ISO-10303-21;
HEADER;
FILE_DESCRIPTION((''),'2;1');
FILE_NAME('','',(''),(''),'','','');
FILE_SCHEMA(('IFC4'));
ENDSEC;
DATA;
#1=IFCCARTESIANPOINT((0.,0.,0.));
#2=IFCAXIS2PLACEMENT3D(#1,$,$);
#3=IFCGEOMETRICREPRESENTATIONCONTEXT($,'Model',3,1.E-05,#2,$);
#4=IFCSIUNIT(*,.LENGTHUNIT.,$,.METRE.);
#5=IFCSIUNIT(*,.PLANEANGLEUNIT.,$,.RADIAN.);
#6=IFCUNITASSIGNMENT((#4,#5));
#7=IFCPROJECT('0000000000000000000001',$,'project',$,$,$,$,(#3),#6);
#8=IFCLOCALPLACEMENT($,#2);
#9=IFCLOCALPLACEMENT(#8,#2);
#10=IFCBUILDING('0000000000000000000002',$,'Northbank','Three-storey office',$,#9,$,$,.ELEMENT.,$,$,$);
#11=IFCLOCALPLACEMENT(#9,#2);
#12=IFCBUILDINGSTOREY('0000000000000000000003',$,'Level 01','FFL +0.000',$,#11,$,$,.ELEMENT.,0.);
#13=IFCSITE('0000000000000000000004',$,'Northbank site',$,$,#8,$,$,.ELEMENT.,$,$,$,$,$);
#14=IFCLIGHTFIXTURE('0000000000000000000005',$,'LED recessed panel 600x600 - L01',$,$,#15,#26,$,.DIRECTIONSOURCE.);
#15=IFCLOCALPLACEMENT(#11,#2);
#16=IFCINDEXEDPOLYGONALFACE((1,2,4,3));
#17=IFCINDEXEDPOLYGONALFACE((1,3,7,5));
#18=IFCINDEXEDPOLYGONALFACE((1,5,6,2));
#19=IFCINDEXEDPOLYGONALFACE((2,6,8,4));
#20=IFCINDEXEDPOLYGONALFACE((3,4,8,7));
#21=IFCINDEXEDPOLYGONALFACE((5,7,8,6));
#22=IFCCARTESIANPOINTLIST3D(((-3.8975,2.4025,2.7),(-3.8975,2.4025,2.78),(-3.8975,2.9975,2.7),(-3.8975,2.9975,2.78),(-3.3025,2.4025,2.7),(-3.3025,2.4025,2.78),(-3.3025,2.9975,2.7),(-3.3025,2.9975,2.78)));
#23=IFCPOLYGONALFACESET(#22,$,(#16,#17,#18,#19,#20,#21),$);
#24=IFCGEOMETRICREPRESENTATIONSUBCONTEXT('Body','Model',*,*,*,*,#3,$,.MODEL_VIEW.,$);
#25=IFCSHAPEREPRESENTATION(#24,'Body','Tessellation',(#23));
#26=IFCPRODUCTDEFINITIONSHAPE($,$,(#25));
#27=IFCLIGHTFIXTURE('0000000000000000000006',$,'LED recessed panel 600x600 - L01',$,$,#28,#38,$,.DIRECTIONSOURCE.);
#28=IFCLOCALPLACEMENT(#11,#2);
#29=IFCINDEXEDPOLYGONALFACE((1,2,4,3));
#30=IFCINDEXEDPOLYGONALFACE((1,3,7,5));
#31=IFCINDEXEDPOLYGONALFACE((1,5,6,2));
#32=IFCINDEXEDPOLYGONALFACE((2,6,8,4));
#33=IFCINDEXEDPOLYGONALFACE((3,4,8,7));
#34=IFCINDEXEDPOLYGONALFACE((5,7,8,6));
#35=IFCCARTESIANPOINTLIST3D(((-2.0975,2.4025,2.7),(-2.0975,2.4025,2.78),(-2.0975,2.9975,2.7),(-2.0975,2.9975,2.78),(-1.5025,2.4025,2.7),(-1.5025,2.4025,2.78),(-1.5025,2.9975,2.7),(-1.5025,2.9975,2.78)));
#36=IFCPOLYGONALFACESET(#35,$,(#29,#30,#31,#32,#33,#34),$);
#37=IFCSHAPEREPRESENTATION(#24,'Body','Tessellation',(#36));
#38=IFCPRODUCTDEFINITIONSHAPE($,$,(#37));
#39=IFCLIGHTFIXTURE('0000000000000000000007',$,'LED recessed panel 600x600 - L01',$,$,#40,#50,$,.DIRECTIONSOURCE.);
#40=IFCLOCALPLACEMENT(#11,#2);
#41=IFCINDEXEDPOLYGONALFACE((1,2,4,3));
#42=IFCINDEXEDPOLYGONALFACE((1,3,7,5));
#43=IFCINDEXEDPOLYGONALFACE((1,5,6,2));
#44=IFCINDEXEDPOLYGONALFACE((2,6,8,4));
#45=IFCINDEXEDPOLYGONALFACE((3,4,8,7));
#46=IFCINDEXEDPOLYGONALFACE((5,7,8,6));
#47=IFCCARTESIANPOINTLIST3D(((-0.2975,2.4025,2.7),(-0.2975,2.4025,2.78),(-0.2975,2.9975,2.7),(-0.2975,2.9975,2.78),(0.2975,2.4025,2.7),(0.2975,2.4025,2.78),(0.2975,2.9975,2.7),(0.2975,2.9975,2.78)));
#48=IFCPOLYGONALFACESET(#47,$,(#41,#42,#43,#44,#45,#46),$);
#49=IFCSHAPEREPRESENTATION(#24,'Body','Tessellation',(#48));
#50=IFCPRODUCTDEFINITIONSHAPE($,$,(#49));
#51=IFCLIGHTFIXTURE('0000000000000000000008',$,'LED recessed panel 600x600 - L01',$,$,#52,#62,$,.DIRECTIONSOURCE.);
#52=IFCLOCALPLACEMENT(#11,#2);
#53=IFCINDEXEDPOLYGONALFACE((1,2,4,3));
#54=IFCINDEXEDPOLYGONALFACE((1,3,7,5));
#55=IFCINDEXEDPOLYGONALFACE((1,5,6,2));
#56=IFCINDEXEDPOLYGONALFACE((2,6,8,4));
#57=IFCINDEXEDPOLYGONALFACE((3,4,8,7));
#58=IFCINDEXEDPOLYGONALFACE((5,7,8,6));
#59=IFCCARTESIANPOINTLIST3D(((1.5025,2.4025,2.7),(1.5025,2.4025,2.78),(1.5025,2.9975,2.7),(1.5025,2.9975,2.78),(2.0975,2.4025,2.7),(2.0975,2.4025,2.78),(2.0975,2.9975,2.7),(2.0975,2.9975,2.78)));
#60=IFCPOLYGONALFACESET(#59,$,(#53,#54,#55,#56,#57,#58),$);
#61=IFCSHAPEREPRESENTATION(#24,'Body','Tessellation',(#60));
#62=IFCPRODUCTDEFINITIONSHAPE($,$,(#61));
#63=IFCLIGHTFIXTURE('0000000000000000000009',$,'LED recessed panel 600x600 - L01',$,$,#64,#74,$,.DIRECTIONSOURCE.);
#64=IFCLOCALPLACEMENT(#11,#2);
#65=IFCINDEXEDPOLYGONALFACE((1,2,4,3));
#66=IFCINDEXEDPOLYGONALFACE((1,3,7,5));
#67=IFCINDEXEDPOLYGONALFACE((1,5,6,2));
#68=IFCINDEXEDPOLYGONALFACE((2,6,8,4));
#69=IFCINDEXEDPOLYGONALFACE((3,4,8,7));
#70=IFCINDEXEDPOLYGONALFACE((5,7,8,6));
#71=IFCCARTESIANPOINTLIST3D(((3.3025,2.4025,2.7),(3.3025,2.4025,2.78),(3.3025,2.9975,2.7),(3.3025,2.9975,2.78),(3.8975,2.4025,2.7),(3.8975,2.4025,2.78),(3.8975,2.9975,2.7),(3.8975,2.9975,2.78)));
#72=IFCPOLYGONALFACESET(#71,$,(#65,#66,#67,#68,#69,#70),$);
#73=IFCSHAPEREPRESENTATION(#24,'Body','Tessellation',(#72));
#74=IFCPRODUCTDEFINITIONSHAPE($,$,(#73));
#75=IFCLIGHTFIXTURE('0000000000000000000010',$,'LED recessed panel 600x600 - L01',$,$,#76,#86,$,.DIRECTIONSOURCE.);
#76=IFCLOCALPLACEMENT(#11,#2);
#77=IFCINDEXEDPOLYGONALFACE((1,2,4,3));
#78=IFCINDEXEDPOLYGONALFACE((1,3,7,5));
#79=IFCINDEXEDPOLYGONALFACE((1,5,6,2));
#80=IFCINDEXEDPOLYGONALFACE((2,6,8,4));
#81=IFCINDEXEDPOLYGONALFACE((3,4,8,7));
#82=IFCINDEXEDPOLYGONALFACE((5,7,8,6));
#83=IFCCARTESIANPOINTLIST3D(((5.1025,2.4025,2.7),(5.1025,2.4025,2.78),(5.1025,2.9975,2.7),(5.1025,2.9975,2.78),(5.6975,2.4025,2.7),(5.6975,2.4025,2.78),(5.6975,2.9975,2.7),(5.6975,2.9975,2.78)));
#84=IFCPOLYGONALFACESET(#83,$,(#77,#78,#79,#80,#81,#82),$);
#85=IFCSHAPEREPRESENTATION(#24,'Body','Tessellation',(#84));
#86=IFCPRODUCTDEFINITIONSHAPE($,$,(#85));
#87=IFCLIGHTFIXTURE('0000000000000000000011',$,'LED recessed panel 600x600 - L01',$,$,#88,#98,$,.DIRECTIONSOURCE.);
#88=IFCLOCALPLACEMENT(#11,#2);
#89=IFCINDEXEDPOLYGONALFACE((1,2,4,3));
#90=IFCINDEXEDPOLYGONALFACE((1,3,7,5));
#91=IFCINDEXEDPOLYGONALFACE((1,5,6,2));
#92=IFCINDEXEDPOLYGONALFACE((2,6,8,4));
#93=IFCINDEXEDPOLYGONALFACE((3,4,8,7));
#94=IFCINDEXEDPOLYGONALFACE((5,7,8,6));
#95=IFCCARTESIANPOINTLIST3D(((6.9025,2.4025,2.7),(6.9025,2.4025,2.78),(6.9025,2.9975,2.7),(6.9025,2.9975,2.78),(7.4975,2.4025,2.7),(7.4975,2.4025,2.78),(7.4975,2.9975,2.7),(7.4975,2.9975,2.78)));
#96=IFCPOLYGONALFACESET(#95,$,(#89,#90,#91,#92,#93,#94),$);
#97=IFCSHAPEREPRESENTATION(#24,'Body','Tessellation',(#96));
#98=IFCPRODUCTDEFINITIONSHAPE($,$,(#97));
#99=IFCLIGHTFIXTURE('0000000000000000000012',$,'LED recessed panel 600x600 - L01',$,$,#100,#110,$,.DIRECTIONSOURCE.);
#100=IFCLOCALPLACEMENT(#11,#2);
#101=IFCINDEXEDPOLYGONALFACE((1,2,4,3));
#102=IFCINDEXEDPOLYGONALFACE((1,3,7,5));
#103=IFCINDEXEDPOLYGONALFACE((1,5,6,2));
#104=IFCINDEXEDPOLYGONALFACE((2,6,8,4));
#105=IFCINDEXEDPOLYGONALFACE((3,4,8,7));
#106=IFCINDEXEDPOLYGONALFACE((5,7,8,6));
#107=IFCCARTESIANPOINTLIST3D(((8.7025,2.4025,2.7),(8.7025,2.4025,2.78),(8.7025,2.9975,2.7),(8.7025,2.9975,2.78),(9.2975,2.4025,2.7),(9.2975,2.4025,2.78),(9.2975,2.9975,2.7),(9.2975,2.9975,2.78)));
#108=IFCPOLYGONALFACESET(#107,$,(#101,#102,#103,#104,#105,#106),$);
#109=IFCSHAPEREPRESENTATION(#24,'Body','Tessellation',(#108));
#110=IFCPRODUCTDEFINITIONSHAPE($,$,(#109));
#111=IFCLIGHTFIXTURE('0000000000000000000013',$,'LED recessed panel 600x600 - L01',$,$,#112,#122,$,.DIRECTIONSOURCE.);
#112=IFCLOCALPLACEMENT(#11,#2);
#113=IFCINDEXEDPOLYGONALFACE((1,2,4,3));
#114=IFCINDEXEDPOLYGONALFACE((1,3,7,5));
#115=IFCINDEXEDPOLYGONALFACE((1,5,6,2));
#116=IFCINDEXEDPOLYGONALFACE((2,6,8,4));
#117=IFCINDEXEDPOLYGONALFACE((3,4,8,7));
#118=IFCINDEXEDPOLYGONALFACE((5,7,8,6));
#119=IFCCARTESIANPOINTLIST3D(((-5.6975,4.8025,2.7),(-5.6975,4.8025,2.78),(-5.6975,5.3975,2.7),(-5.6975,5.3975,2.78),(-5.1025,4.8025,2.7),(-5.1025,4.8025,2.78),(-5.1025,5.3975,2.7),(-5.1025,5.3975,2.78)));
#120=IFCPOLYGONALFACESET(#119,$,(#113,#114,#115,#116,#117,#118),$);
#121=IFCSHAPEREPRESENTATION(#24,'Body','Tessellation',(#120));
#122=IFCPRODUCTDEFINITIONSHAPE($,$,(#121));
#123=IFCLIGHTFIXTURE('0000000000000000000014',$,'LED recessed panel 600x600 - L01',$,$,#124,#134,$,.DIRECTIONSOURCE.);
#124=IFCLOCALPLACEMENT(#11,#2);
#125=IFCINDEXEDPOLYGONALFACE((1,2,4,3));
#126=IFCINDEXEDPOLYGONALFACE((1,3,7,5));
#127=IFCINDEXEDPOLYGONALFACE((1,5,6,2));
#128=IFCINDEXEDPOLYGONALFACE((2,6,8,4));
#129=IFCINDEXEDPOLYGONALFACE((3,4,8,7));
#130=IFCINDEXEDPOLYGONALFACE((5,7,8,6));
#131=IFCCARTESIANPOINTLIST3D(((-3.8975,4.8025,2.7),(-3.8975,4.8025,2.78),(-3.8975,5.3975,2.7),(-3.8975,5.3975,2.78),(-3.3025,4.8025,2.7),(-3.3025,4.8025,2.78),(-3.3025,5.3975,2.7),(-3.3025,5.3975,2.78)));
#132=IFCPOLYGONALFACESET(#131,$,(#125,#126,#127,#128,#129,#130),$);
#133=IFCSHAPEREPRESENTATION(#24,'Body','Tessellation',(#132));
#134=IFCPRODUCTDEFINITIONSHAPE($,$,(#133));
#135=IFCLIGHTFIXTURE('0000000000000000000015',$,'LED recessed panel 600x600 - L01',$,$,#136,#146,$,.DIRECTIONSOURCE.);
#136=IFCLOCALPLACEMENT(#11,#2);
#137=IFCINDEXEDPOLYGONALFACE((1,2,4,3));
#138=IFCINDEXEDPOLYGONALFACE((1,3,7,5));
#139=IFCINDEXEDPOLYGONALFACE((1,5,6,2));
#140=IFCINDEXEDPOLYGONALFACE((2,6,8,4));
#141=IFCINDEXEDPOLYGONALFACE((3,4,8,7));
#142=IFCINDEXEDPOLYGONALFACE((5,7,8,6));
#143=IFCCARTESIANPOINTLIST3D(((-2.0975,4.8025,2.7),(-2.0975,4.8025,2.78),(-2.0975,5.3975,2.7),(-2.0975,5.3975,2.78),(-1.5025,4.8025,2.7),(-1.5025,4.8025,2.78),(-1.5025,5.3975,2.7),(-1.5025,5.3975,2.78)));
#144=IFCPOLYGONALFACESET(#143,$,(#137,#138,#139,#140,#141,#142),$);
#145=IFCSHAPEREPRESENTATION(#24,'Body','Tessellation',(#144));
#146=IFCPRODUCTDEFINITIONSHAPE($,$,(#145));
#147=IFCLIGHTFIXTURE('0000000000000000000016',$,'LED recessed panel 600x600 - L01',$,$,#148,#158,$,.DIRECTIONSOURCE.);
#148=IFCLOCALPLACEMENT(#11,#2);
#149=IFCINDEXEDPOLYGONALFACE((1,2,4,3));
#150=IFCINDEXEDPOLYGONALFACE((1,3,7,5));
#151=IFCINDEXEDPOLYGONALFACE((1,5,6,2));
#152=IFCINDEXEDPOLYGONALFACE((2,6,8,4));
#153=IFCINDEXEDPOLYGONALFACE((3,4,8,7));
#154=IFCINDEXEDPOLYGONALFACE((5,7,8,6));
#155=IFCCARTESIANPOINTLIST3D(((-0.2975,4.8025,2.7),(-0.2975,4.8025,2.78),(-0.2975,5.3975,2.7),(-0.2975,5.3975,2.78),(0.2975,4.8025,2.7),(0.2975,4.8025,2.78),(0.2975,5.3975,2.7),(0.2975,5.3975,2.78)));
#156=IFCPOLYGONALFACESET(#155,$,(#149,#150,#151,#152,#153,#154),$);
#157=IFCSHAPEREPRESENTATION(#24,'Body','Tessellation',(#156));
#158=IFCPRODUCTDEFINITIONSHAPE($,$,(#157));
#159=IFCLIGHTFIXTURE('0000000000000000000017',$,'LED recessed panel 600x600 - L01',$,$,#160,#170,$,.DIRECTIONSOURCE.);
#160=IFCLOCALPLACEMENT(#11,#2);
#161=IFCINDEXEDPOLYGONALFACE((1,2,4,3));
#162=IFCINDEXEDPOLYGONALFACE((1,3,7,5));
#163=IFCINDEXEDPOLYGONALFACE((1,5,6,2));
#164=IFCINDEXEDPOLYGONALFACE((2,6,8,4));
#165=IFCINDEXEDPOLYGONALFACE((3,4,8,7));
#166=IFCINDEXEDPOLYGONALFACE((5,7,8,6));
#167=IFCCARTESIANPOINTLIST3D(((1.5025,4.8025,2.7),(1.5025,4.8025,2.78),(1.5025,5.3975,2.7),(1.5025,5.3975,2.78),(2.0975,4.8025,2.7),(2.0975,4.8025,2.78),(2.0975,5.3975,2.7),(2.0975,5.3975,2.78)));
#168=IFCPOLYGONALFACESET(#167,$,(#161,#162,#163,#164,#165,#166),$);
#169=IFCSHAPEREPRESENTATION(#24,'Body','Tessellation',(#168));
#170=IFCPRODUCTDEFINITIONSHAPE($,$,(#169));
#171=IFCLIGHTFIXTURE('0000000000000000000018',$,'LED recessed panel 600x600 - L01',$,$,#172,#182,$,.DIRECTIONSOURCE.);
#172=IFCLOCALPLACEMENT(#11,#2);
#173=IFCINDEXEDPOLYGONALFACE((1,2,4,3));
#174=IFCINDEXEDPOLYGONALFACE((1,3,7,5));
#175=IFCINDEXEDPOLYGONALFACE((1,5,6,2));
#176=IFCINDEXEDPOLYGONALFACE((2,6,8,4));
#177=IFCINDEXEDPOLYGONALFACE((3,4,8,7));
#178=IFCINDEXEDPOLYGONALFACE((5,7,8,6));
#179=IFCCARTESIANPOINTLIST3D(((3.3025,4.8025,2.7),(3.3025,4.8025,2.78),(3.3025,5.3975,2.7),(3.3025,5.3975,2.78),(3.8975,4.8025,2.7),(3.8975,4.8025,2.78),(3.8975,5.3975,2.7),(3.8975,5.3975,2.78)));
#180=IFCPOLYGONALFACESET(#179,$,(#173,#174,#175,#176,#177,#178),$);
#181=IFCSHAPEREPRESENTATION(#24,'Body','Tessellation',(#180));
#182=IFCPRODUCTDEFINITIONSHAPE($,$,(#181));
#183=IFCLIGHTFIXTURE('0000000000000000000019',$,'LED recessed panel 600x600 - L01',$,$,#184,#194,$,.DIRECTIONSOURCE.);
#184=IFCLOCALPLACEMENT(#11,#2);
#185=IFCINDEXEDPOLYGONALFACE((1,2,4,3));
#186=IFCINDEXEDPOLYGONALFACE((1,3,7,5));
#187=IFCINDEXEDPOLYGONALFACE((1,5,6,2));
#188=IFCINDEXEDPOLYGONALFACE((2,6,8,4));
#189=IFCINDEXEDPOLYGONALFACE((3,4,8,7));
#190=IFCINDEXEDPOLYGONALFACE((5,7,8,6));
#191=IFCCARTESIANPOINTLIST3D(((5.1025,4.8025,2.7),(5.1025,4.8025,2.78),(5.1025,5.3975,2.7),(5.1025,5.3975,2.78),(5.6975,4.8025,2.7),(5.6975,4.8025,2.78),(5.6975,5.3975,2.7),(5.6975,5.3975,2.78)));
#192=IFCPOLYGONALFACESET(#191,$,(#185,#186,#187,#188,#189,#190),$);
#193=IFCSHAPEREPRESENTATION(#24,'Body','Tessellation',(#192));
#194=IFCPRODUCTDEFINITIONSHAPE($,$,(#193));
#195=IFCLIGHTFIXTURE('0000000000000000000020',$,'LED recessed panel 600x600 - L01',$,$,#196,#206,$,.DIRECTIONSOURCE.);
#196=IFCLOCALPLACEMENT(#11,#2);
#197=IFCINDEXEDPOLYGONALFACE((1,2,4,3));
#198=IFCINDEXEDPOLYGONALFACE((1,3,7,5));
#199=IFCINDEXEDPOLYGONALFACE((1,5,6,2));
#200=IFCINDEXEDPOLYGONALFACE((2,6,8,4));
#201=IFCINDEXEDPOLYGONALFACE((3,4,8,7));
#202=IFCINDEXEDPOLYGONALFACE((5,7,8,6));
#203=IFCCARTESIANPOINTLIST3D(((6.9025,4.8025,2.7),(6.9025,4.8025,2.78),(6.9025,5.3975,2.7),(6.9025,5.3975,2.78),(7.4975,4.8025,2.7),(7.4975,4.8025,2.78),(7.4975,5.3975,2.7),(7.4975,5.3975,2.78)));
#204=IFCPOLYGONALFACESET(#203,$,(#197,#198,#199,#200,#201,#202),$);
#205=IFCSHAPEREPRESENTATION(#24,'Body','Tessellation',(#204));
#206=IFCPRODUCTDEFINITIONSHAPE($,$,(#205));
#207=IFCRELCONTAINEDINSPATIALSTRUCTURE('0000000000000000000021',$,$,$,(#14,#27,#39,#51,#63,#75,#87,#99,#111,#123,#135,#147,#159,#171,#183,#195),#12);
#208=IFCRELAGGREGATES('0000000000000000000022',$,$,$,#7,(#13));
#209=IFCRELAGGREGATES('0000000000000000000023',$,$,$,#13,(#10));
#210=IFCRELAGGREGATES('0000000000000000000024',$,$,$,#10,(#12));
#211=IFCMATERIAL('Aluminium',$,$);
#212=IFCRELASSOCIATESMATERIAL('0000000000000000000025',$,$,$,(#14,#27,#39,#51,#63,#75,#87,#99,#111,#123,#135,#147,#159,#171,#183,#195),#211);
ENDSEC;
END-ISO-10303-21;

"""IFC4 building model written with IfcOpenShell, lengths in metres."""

from ifc_helpers import new_model, si_unit, frame, origin, place, context, subcontext, project, spatial, rectangle, extrude, material, element, save


model = new_model("IFC4")

# Units and contexts
model_context = context("Model", 3, precision=1e-05, world=origin())
body_context = subcontext(model_context, "Body", "Model", "MODEL_VIEW")
ifc_project = project(units=[si_unit("LENGTHUNIT", "METRE"), si_unit("PLANEANGLEUNIT", "RADIAN")], contexts=[model_context])

# Site, building, storey
site_placement = place(None, origin())
site = spatial("IfcSite", under=ifc_project, at=site_placement, Name="Northbank site", CompositionType="ELEMENT")
building_placement = place(site_placement, origin())
building = spatial("IfcBuilding", under=site, at=building_placement, Name="Northbank", Description="Three-storey office", CompositionType="ELEMENT")
storey_placement = place(building_placement, origin())
storey = spatial("IfcBuildingStorey", under=building, at=storey_placement, Name="Level 01", Description="FFL +0.000", CompositionType="ELEMENT", Elevation=0.0)

# Light fixtures
ifc_material_1 = material(Name="Aluminium")
light_fixture_1_placement = place(storey_placement, origin())
element("IfcLightFixture", 1, at=light_fixture_1_placement, inside=storey, material=ifc_material_1, Name="LED recessed panel 600x600 - L01", PredefinedType="DIRECTIONSOURCE", context=body_context, shape_type="SweptSolid", body=[
    extrude(rectangle(XDim=0.595, YDim=0.595), frame((-3.6, 2.7, 2.7)), (0.0, 0.0, 1.0), 0.08),
])
light_fixture_2_placement = place(storey_placement, origin())
element("IfcLightFixture", 2, at=light_fixture_2_placement, inside=storey, material=ifc_material_1, Name="LED recessed panel 600x600 - L01", PredefinedType="DIRECTIONSOURCE", context=body_context, shape_type="SweptSolid", body=[
    extrude(rectangle(XDim=0.595, YDim=0.595), frame((-1.8, 2.7, 2.7)), (0.0, 0.0, 1.0), 0.08),
])
light_fixture_3_placement = place(storey_placement, origin())
element("IfcLightFixture", 3, at=light_fixture_3_placement, inside=storey, material=ifc_material_1, Name="LED recessed panel 600x600 - L01", PredefinedType="DIRECTIONSOURCE", context=body_context, shape_type="SweptSolid", body=[
    extrude(rectangle(XDim=0.595, YDim=0.595), frame((0.0, 2.7, 2.7)), (0.0, 0.0, 1.0), 0.08),
])
light_fixture_4_placement = place(storey_placement, origin())
element("IfcLightFixture", 4, at=light_fixture_4_placement, inside=storey, material=ifc_material_1, Name="LED recessed panel 600x600 - L01", PredefinedType="DIRECTIONSOURCE", context=body_context, shape_type="SweptSolid", body=[
    extrude(rectangle(XDim=0.595, YDim=0.595), frame((1.8, 2.7, 2.7)), (0.0, 0.0, 1.0), 0.08),
])
light_fixture_5_placement = place(storey_placement, origin())
element("IfcLightFixture", 5, at=light_fixture_5_placement, inside=storey, material=ifc_material_1, Name="LED recessed panel 600x600 - L01", PredefinedType="DIRECTIONSOURCE", context=body_context, shape_type="SweptSolid", body=[
    extrude(rectangle(XDim=0.595, YDim=0.595), frame((3.6, 2.7, 2.7)), (0.0, 0.0, 1.0), 0.08),
])
light_fixture_6_placement = place(storey_placement, origin())
element("IfcLightFixture", 6, at=light_fixture_6_placement, inside=storey, material=ifc_material_1, Name="LED recessed panel 600x600 - L01", PredefinedType="DIRECTIONSOURCE", context=body_context, shape_type="SweptSolid", body=[
    extrude(rectangle(XDim=0.595, YDim=0.595), frame((5.4, 2.7, 2.7)), (0.0, 0.0, 1.0), 0.08),
])
light_fixture_7_placement = place(storey_placement, origin())
element("IfcLightFixture", 7, at=light_fixture_7_placement, inside=storey, material=ifc_material_1, Name="LED recessed panel 600x600 - L01", PredefinedType="DIRECTIONSOURCE", context=body_context, shape_type="SweptSolid", body=[
    extrude(rectangle(XDim=0.595, YDim=0.595), frame((7.2, 2.7, 2.7)), (0.0, 0.0, 1.0), 0.08),
])
light_fixture_8_placement = place(storey_placement, origin())
element("IfcLightFixture", 8, at=light_fixture_8_placement, inside=storey, material=ifc_material_1, Name="LED recessed panel 600x600 - L01", PredefinedType="DIRECTIONSOURCE", context=body_context, shape_type="SweptSolid", body=[
    extrude(rectangle(XDim=0.595, YDim=0.595), frame((9.0, 2.7, 2.7)), (0.0, 0.0, 1.0), 0.08),
])
light_fixture_9_placement = place(storey_placement, origin())
element("IfcLightFixture", 9, at=light_fixture_9_placement, inside=storey, material=ifc_material_1, Name="LED recessed panel 600x600 - L01", PredefinedType="DIRECTIONSOURCE", context=body_context, shape_type="SweptSolid", body=[
    extrude(rectangle(XDim=0.595, YDim=0.595), frame((-5.4, 5.1, 2.7)), (0.0, 0.0, 1.0), 0.08),
])
light_fixture_10_placement = place(storey_placement, origin())
element("IfcLightFixture", 10, at=light_fixture_10_placement, inside=storey, material=ifc_material_1, Name="LED recessed panel 600x600 - L01", PredefinedType="DIRECTIONSOURCE", context=body_context, shape_type="SweptSolid", body=[
    extrude(rectangle(XDim=0.595, YDim=0.595), frame((-3.6, 5.1, 2.7)), (0.0, 0.0, 1.0), 0.08),
])
light_fixture_11_placement = place(storey_placement, origin())
element("IfcLightFixture", 11, at=light_fixture_11_placement, inside=storey, material=ifc_material_1, Name="LED recessed panel 600x600 - L01", PredefinedType="DIRECTIONSOURCE", context=body_context, shape_type="SweptSolid", body=[
    extrude(rectangle(XDim=0.595, YDim=0.595), frame((-1.8, 5.1, 2.7)), (0.0, 0.0, 1.0), 0.08),
])
light_fixture_12_placement = place(storey_placement, origin())
element("IfcLightFixture", 12, at=light_fixture_12_placement, inside=storey, material=ifc_material_1, Name="LED recessed panel 600x600 - L01", PredefinedType="DIRECTIONSOURCE", context=body_context, shape_type="SweptSolid", body=[
    extrude(rectangle(XDim=0.595, YDim=0.595), frame((0.0, 5.1, 2.7)), (0.0, 0.0, 1.0), 0.08),
])
light_fixture_13_placement = place(storey_placement, origin())
element("IfcLightFixture", 13, at=light_fixture_13_placement, inside=storey, material=ifc_material_1, Name="LED recessed panel 600x600 - L01", PredefinedType="DIRECTIONSOURCE", context=body_context, shape_type="SweptSolid", body=[
    extrude(rectangle(XDim=0.595, YDim=0.595), frame((1.8, 5.1, 2.7)), (0.0, 0.0, 1.0), 0.08),
])
light_fixture_14_placement = place(storey_placement, origin())
element("IfcLightFixture", 14, at=light_fixture_14_placement, inside=storey, material=ifc_material_1, Name="LED recessed panel 600x600 - L01", PredefinedType="DIRECTIONSOURCE", context=body_context, shape_type="SweptSolid", body=[
    extrude(rectangle(XDim=0.595, YDim=0.595), frame((3.6, 5.1, 2.7)), (0.0, 0.0, 1.0), 0.08),
])
light_fixture_15_placement = place(storey_placement, origin())
element("IfcLightFixture", 15, at=light_fixture_15_placement, inside=storey, material=ifc_material_1, Name="LED recessed panel 600x600 - L01", PredefinedType="DIRECTIONSOURCE", context=body_context, shape_type="SweptSolid", body=[
    extrude(rectangle(XDim=0.595, YDim=0.595), frame((5.4, 5.1, 2.7)), (0.0, 0.0, 1.0), 0.08),
])
light_fixture_16_placement = place(storey_placement, origin())
element("IfcLightFixture", 16, at=light_fixture_16_placement, inside=storey, material=ifc_material_1, Name="LED recessed panel 600x600 - L01", PredefinedType="DIRECTIONSOURCE", context=body_context, shape_type="SweptSolid", body=[
    extrude(rectangle(XDim=0.595, YDim=0.595), frame((7.2, 5.1, 2.7)), (0.0, 0.0, 1.0), 0.08),
])

save(model, "model.ifc")
